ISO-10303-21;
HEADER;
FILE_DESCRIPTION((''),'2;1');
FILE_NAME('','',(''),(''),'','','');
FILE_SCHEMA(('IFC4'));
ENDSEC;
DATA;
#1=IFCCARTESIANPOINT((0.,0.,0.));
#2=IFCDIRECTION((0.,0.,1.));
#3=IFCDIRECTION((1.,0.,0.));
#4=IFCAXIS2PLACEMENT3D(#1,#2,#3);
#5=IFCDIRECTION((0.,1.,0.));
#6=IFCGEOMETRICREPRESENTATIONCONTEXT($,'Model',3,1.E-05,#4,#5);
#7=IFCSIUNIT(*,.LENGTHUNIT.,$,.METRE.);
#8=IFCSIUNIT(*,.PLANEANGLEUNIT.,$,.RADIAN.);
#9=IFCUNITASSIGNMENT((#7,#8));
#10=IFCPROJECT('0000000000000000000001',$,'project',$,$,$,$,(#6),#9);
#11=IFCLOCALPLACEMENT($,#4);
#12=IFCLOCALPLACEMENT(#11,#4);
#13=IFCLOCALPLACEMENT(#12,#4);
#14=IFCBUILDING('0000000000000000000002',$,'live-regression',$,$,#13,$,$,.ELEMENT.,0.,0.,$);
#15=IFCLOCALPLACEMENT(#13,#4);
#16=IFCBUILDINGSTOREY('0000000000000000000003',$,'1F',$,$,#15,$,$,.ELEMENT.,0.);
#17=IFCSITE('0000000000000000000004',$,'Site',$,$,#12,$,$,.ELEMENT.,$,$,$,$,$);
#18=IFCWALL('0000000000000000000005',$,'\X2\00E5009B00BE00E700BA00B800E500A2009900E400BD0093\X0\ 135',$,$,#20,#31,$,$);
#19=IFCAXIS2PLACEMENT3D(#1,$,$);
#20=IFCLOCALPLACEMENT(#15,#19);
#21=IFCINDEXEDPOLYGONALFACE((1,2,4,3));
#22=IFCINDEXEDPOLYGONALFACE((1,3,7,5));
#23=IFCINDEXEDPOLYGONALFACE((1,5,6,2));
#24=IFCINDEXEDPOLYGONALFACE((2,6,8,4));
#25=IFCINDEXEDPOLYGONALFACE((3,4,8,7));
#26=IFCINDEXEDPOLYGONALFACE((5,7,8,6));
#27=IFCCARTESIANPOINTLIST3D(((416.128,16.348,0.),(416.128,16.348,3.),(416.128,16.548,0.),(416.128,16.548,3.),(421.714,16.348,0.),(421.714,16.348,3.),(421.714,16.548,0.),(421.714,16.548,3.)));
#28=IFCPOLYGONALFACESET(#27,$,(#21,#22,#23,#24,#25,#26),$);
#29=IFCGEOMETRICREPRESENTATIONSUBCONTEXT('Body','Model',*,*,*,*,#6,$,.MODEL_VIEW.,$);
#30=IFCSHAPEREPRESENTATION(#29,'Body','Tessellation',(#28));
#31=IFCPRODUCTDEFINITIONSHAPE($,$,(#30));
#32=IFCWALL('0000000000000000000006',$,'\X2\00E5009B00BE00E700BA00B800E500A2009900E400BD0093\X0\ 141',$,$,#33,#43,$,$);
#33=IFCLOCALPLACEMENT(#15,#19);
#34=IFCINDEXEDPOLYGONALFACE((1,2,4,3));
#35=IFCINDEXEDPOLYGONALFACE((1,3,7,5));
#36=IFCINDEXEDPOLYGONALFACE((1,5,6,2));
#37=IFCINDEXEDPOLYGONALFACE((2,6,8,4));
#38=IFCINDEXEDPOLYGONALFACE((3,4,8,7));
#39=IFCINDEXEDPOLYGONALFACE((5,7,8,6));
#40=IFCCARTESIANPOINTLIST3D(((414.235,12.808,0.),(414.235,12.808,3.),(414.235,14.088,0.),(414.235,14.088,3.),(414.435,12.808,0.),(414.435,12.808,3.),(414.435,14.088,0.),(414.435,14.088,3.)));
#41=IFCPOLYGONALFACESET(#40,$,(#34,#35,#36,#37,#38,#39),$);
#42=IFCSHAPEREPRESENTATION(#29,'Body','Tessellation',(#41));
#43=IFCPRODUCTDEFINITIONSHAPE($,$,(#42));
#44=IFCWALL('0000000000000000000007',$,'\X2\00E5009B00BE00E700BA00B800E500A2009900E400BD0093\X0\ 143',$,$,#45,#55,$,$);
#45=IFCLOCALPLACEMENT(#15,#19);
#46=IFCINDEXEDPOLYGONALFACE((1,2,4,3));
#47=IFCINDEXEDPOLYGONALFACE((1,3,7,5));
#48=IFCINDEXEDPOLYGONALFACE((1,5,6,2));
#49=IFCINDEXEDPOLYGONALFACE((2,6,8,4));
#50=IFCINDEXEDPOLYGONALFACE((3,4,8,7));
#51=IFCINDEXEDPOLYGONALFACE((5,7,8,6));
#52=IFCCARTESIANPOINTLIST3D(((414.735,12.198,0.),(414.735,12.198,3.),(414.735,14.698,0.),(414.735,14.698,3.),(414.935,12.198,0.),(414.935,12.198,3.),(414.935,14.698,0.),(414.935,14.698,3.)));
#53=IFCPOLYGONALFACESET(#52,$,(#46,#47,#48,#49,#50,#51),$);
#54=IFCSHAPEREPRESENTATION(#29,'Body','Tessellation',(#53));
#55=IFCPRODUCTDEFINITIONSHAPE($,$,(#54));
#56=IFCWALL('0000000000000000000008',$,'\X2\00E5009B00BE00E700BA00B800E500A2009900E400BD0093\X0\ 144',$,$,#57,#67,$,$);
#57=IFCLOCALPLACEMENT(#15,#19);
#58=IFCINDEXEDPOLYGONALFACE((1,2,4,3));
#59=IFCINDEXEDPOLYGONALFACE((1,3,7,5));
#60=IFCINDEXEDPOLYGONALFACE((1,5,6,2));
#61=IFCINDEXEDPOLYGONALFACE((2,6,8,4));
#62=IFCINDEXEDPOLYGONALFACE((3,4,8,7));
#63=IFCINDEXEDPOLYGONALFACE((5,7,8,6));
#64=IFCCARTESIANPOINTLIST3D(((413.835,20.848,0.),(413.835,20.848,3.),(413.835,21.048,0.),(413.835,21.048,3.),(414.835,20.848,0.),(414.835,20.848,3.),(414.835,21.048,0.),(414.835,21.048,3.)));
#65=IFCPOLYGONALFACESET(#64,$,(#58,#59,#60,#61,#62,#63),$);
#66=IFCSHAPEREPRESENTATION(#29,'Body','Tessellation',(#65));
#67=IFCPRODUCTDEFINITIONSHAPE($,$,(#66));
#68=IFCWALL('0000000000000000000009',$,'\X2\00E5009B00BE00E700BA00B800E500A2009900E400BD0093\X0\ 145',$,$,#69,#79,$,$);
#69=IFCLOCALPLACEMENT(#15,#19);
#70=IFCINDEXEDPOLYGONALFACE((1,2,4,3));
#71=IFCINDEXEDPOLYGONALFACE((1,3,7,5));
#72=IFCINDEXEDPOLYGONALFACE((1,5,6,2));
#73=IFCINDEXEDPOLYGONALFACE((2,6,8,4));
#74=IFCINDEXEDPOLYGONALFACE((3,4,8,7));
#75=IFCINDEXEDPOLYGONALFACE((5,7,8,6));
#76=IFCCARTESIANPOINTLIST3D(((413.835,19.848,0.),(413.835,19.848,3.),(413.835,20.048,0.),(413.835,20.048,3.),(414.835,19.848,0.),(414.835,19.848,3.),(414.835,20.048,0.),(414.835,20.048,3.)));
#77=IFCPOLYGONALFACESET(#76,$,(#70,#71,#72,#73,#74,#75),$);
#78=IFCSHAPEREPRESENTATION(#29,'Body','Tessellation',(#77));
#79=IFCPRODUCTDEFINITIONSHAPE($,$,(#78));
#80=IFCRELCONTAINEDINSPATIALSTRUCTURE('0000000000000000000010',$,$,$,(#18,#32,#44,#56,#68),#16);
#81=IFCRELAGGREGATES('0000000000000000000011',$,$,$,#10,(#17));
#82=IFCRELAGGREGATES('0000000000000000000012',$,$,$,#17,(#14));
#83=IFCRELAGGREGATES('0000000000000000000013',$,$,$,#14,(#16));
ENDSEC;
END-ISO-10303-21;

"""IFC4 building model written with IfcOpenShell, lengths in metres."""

from ifc_helpers import new_model, si_unit, direction, frame, frame_2d, origin_with_axes, place, context, subcontext, project, spatial, rectangle, extrude, element, save


model = new_model("IFC4")

# Units and contexts
model_context = context("Model", 3, precision=1e-05, world=origin_with_axes(), true_north=direction((0.0, 1.0, 0.0)))
body_context = subcontext(model_context, "Body", "Model", "MODEL_VIEW")
ifc_project = project(units=[si_unit("LENGTHUNIT", "METRE"), si_unit("PLANEANGLEUNIT", "RADIAN")], contexts=[model_context])

# Site, building, storey
placement = place(None, origin_with_axes())
site_placement = place(placement, origin_with_axes())
site = spatial("IfcSite", under=ifc_project, at=site_placement, Name="Site", CompositionType="ELEMENT")
building_placement = place(site_placement, origin_with_axes())
building = spatial("IfcBuilding", under=site, at=building_placement, Name="live-regression", CompositionType="ELEMENT", ElevationOfRefHeight=0.0, ElevationOfTerrain=0.0)
storey_placement = place(building_placement, origin_with_axes())
storey = spatial("IfcBuildingStorey", under=building, at=storey_placement, Name="1F", CompositionType="ELEMENT", Elevation=0.0)

# Walls
wall_1_placement = place(storey_placement, frame((418.921, 16.448, 0.0), z_axis=(0.0, 0.0, 1.0), x_axis=(-1.0, 0.0, 0.0)))
element("IfcWall", 1, at=wall_1_placement, inside=storey, Name="å\u009b¾çº¸å¢\u0099ä½\u0093 135", context=body_context, shape_type="SweptSolid", body=[
    extrude(rectangle(XDim=5.586, YDim=0.2, at=frame_2d((0.0, 0.0), x_axis=(1.0, 0.0, 0.0))), frame((0.0, 0.0, 0.0), z_axis=(0.0, 0.0, 1.0)), (0.0, 0.0, 1.0), 3.0),
])
wall_2_placement = place(storey_placement, frame((414.335, 13.448, 0.0), z_axis=(0.0, 0.0, 1.0), x_axis=(0.0, -1.0, 0.0)))
element("IfcWall", 2, at=wall_2_placement, inside=storey, Name="å\u009b¾çº¸å¢\u0099ä½\u0093 141", context=body_context, shape_type="SweptSolid", body=[
    extrude(rectangle(XDim=1.28, YDim=0.2, at=frame_2d((0.0, 0.0), x_axis=(1.0, 0.0, 0.0))), frame((0.0, 0.0, 0.0), z_axis=(0.0, 0.0, 1.0)), (0.0, 0.0, 1.0), 3.0),
])
wall_3_placement = place(storey_placement, frame((414.835, 13.448, 0.0), z_axis=(0.0, 0.0, 1.0), x_axis=(0.0, 1.0, 0.0)))
element("IfcWall", 3, at=wall_3_placement, inside=storey, Name="å\u009b¾çº¸å¢\u0099ä½\u0093 143", context=body_context, shape_type="SweptSolid", body=[
    extrude(rectangle(XDim=2.5, YDim=0.2, at=frame_2d((0.0, 0.0), x_axis=(1.0, 0.0, 0.0))), frame((0.0, 0.0, 0.0), z_axis=(0.0, 0.0, 1.0)), (0.0, 0.0, 1.0), 3.0),
])
for number, where, z_axis, x_axis, name in (
    (4, (414.335, 20.948, 0.0), (0.0, 0.0, 1.0), (-1.0, 0.0, 0.0), "å\u009b¾çº¸å¢\u0099ä½\u0093 144"),
    (5, (414.335, 19.948, 0.0), (0.0, 0.0, 1.0), (-1.0, 0.0, 0.0), "å\u009b¾çº¸å¢\u0099ä½\u0093 145"),
):
    element("IfcWall", number, at=place(storey_placement, frame(where, z_axis=z_axis, x_axis=x_axis)), inside=storey, Name=name, context=body_context, shape_type="SweptSolid", body=[
        extrude(rectangle(XDim=1.0, YDim=0.2, at=frame_2d((0.0, 0.0), x_axis=(1.0, 0.0, 0.0))), frame((0.0, 0.0, 0.0), z_axis=(0.0, 0.0, 1.0)), (0.0, 0.0, 1.0), 3.0),
    ])

save(model, "model.ifc")
